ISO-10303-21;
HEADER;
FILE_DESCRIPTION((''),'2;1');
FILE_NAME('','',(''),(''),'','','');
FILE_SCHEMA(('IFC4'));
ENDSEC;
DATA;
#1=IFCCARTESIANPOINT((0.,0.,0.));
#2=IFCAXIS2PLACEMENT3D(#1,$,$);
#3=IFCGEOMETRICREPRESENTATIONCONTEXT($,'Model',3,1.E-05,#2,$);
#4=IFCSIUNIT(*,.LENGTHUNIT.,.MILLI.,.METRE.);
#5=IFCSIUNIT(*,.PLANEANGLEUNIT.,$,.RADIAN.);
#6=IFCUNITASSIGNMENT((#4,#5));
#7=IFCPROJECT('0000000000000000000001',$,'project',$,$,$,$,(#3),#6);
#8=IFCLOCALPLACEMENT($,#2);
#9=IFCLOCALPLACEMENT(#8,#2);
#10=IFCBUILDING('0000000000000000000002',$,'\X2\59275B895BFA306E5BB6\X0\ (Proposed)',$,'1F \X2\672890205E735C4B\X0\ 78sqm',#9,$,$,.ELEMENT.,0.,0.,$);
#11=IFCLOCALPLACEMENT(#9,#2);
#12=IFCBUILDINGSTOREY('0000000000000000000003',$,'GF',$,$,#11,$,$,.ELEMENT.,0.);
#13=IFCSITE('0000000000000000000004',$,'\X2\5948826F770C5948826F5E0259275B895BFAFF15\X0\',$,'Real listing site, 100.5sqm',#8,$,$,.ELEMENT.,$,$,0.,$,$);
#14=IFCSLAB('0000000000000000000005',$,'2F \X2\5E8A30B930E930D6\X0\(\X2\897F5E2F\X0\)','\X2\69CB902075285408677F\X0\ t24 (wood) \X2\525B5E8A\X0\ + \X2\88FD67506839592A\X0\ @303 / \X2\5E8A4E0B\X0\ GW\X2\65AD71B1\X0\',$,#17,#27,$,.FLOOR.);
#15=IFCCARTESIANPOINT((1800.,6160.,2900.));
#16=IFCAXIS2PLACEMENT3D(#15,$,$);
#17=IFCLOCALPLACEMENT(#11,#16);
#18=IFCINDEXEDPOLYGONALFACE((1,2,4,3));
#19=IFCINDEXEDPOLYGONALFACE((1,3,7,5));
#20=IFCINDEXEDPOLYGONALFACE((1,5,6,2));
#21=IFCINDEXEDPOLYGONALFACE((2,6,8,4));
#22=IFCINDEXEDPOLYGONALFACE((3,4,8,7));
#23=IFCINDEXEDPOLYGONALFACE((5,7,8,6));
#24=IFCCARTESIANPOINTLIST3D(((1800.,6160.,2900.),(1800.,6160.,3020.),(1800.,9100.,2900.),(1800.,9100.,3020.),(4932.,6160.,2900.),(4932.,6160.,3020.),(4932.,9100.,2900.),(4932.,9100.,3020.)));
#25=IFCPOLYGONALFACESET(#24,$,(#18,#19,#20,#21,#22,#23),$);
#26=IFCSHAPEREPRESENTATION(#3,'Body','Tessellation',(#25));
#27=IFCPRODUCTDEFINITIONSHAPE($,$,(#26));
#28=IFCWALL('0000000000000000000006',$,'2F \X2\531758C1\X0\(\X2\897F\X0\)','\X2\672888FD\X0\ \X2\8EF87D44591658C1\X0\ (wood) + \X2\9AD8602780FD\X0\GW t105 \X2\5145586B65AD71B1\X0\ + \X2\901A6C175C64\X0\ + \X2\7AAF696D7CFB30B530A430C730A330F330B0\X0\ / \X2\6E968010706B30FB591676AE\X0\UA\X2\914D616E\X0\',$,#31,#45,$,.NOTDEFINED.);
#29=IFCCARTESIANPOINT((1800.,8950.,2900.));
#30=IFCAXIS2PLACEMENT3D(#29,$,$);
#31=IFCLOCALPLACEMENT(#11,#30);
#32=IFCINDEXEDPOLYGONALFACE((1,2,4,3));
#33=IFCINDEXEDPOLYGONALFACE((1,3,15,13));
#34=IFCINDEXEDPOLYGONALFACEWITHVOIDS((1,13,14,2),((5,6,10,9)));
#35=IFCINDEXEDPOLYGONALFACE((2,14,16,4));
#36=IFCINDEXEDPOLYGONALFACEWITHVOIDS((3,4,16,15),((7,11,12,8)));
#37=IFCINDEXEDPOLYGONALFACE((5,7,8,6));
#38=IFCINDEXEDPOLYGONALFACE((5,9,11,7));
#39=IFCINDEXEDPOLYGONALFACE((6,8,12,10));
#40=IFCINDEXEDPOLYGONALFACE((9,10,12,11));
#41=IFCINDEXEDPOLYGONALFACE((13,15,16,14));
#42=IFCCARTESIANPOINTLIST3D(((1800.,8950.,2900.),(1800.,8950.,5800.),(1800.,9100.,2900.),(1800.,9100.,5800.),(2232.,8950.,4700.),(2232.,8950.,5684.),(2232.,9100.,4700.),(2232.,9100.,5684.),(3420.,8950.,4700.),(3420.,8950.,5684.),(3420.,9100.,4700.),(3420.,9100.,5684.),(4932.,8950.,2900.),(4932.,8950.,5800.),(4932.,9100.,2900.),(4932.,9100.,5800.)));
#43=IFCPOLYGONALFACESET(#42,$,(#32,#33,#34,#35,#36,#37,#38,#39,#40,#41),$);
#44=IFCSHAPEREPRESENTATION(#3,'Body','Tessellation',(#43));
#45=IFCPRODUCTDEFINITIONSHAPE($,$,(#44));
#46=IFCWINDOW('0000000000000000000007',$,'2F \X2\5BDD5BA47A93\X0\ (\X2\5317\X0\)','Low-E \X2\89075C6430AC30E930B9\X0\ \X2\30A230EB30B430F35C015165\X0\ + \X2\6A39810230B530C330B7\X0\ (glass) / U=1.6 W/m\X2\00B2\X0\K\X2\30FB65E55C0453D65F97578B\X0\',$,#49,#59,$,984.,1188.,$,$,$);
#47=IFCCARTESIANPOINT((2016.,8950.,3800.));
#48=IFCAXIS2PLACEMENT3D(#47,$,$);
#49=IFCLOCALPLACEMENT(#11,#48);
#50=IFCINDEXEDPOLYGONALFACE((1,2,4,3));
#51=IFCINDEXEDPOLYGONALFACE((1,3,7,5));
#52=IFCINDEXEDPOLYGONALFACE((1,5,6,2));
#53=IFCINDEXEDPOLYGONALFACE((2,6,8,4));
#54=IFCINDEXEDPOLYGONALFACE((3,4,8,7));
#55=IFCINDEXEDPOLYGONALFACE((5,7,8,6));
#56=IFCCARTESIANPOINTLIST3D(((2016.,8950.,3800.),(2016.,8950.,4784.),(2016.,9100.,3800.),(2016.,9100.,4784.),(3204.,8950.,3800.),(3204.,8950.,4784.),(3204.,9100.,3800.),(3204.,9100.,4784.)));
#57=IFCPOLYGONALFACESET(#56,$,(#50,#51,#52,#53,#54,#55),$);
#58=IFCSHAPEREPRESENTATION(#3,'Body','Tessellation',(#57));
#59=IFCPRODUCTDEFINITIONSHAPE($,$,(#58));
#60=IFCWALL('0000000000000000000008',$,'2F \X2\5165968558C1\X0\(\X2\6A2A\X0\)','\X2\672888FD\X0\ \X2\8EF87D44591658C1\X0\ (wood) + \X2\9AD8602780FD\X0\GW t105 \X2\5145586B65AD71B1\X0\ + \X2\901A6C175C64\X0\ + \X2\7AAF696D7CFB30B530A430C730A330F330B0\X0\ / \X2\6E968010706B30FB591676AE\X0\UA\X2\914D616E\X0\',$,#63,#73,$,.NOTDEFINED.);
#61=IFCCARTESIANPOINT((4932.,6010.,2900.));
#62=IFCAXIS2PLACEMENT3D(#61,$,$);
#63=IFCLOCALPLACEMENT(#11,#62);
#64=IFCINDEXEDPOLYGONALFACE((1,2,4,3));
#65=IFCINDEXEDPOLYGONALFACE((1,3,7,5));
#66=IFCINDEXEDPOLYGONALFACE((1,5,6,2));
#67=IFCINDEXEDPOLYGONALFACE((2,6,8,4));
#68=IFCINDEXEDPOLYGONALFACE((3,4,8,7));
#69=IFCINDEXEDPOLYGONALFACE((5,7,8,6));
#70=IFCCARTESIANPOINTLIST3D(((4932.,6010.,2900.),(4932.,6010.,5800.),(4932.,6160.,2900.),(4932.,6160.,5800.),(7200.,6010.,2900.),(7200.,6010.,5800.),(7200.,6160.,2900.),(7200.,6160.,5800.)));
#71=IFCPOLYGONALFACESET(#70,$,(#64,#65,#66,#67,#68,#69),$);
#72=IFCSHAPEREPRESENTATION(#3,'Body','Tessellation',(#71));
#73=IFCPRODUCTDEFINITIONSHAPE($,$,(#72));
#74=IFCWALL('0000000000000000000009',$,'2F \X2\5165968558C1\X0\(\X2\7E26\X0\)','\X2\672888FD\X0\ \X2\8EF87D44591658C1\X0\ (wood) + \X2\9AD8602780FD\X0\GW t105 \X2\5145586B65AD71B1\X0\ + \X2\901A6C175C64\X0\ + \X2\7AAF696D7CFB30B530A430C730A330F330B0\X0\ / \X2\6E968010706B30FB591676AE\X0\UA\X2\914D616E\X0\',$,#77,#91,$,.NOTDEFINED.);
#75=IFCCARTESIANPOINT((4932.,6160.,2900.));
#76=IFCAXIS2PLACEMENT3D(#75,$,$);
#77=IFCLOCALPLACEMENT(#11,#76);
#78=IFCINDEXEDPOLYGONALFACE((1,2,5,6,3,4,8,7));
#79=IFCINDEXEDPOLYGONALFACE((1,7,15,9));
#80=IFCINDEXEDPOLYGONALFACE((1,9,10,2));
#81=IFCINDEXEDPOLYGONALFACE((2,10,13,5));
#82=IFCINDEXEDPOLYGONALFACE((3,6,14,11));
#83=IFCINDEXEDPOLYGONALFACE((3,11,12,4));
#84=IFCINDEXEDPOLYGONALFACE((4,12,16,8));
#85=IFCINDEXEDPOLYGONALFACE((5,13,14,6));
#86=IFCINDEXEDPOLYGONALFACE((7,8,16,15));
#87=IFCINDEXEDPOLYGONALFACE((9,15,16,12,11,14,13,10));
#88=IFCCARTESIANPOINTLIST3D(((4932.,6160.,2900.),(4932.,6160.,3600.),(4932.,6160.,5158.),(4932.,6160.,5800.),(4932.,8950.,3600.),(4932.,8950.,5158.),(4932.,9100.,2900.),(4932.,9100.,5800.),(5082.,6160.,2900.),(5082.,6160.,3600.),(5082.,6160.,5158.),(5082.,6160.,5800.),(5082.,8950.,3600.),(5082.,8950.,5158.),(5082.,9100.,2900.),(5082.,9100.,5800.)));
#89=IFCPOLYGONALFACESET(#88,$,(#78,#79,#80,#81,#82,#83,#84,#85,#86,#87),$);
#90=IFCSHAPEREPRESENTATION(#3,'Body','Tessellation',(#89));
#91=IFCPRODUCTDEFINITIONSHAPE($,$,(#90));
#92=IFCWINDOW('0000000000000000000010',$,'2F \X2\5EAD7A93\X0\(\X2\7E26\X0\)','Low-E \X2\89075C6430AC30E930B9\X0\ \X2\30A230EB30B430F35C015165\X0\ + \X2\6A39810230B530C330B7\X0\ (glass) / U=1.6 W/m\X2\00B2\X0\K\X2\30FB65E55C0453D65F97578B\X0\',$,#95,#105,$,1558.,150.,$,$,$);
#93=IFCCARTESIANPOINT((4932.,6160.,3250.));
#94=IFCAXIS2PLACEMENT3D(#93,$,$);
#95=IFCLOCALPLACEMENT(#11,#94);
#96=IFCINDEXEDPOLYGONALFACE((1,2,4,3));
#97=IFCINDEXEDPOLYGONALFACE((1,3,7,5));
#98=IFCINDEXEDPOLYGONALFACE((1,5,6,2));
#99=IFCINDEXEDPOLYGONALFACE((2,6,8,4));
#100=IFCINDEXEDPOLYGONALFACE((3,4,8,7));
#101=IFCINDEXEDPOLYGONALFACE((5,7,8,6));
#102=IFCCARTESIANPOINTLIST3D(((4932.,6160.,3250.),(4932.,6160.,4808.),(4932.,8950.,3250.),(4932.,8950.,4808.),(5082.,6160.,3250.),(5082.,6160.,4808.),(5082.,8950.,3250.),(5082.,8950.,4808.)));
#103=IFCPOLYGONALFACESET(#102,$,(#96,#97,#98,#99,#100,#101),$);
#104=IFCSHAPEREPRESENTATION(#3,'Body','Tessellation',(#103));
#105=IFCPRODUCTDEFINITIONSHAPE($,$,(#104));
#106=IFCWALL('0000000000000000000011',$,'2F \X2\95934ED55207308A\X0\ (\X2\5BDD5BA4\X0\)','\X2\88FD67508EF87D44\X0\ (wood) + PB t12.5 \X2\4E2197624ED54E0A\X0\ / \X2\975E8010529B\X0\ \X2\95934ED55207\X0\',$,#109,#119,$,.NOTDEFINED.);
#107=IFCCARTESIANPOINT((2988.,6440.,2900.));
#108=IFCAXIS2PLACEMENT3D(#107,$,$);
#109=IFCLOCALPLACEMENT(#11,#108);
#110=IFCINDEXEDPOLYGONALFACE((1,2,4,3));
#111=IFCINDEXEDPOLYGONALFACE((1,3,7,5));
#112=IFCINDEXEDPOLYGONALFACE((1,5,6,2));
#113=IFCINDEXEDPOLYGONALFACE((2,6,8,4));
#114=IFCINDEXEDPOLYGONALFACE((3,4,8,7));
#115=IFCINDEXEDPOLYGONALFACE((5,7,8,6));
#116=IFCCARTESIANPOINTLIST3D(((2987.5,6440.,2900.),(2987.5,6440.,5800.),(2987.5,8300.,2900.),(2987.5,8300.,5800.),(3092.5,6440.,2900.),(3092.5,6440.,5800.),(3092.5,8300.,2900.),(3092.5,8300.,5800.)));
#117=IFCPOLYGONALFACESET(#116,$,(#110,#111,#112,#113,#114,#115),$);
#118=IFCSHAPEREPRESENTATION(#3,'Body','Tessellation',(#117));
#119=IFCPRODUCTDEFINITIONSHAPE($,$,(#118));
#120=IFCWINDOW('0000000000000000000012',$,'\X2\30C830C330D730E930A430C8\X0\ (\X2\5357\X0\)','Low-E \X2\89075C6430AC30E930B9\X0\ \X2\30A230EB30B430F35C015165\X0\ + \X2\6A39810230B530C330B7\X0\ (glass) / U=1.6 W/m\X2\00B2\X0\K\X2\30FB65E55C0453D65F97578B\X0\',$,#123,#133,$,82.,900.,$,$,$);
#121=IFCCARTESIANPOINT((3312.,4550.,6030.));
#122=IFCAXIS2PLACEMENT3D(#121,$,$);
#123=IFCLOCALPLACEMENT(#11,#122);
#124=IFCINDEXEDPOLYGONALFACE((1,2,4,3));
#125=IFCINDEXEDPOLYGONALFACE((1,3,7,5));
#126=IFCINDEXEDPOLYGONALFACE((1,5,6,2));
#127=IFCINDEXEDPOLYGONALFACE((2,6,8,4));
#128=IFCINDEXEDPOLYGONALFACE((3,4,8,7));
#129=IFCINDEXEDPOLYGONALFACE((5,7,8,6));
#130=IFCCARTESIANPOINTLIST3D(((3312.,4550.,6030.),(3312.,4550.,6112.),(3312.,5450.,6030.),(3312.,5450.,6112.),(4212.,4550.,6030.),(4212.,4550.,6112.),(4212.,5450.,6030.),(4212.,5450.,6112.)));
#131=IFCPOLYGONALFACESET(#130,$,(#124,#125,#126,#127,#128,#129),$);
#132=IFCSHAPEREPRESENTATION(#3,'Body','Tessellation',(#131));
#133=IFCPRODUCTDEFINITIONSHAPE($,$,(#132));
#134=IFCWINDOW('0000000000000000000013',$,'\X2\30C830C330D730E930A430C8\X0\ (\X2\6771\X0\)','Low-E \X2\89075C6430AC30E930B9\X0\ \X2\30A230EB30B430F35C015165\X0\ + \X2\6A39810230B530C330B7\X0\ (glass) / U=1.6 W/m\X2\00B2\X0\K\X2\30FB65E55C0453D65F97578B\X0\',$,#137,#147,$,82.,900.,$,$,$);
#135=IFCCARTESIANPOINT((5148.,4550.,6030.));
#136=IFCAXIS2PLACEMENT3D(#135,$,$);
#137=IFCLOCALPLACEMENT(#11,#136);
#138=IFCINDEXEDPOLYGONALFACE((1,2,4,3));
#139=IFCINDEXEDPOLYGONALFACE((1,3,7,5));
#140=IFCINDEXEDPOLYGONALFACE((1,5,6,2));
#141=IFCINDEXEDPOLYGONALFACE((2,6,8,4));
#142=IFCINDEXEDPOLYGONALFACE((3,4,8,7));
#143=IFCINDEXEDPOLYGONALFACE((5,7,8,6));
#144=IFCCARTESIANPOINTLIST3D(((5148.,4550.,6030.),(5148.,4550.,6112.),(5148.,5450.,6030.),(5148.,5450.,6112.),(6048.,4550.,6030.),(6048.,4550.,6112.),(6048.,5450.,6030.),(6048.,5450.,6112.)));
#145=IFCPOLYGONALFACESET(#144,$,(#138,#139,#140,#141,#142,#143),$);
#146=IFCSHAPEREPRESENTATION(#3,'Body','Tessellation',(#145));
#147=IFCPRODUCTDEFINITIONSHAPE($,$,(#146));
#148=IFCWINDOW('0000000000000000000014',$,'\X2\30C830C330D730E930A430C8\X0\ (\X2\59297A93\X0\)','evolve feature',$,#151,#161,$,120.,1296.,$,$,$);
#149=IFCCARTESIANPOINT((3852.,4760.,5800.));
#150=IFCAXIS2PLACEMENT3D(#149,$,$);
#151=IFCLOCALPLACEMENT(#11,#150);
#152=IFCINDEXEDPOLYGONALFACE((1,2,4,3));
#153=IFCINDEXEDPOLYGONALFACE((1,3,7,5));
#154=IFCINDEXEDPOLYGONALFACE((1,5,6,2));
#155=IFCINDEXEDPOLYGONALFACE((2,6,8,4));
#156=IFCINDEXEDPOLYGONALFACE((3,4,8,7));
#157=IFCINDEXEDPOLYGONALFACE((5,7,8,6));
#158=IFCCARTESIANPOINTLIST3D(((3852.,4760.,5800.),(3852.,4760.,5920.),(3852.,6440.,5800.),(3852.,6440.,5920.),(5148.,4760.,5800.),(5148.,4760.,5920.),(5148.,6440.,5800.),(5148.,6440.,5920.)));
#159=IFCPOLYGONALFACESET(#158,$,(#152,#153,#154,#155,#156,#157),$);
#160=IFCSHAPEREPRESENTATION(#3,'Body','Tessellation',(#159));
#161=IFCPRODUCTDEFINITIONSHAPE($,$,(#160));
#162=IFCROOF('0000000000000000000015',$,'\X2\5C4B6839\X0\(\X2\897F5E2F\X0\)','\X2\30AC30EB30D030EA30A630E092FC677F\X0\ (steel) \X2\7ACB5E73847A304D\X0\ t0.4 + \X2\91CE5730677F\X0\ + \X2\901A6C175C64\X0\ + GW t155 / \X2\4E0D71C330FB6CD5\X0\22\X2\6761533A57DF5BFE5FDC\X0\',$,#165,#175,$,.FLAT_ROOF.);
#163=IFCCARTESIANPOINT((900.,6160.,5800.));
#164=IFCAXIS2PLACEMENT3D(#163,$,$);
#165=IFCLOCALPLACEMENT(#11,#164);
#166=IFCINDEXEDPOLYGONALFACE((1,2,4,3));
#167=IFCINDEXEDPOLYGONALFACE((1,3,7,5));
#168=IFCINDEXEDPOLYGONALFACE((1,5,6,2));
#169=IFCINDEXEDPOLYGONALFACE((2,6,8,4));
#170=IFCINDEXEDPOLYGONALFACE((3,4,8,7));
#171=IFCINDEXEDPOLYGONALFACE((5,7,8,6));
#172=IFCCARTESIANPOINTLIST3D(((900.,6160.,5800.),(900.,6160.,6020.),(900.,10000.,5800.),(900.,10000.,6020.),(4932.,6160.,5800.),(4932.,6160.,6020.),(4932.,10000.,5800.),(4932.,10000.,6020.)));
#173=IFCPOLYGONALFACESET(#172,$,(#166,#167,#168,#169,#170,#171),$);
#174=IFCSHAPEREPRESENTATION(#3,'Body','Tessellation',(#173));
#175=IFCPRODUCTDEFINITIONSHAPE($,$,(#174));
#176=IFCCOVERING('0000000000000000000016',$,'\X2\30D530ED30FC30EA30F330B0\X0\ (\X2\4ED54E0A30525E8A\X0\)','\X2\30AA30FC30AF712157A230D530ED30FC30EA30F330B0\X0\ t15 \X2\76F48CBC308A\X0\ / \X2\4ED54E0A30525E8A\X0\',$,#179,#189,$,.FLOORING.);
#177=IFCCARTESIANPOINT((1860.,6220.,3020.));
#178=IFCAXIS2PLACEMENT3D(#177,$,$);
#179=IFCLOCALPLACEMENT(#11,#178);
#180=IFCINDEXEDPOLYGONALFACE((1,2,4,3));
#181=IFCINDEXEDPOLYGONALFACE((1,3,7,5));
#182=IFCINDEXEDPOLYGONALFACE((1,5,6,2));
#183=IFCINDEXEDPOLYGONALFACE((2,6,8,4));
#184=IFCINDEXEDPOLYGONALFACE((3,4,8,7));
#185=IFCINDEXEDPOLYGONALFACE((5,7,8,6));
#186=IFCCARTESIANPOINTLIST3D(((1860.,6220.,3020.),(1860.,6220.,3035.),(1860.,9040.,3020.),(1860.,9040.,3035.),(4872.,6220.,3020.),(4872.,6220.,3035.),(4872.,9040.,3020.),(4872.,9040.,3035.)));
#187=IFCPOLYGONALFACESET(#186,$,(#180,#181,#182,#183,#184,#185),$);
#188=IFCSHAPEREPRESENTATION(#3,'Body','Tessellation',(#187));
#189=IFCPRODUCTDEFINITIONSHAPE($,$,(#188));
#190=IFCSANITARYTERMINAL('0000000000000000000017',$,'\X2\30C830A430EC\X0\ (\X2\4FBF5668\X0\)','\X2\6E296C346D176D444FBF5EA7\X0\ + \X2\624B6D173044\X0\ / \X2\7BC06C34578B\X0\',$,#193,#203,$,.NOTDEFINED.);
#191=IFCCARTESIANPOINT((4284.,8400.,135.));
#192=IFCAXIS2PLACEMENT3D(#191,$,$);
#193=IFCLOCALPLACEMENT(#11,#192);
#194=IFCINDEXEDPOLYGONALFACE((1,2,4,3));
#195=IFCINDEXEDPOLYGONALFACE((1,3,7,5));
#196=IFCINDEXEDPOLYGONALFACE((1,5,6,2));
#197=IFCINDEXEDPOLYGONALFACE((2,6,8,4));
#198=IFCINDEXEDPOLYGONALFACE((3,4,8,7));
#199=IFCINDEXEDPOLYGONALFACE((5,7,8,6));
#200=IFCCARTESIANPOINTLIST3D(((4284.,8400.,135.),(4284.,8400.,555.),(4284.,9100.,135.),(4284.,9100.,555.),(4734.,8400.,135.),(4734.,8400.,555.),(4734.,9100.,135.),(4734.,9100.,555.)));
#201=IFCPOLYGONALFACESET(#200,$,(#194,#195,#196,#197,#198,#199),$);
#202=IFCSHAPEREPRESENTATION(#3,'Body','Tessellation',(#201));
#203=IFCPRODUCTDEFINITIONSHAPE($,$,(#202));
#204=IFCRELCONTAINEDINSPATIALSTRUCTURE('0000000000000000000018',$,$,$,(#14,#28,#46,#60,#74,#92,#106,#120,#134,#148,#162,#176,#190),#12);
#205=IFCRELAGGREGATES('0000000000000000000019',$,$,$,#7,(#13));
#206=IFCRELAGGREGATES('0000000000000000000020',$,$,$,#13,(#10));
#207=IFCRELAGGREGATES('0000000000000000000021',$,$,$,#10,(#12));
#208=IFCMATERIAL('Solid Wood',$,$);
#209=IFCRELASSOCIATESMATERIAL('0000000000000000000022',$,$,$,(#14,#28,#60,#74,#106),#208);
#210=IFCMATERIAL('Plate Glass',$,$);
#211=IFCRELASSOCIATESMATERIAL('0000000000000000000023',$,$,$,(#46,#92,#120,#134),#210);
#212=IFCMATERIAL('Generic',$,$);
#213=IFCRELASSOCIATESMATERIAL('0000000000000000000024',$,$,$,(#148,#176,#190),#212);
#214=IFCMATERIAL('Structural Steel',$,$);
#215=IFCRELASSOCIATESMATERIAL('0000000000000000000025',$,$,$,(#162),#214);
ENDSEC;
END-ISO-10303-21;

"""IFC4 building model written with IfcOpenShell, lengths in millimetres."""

from ifc_helpers import new_model, si_unit, frame, frame_2d, origin, place, context, project, spatial, rectangle, extrude, material, element, fill, save


model = new_model("IFC4")

# Units and contexts
model_context = context("Model", 3, precision=1e-05, world=origin())
ifc_project = project(units=[si_unit("LENGTHUNIT", "METRE", prefix="MILLI"), si_unit("PLANEANGLEUNIT", "RADIAN")], contexts=[model_context])

# Site, building, storey
site_placement = place(None, origin())
site = spatial("IfcSite", under=ifc_project, at=site_placement, Name="奈良県奈良市大安寺５", ObjectType="Real listing site, 100.5sqm", CompositionType="ELEMENT", RefElevation=0.0)
building_placement = place(site_placement, origin())
building = spatial("IfcBuilding", under=site, at=building_placement, Name="大安寺の家 (Proposed)", ObjectType="1F 木造平屋 78sqm", CompositionType="ELEMENT", ElevationOfRefHeight=0.0, ElevationOfTerrain=0.0)
storey_placement = place(building_placement, origin())
storey = spatial("IfcBuildingStorey", under=building, at=storey_placement, Name="GF", CompositionType="ELEMENT", Elevation=0.0)

# Slab
ifc_material_1 = material(Name="Solid Wood")
slab_placement = place(storey_placement, frame((1800.0, 6160.0, 2900.0)))
element("IfcSlab", 1, at=slab_placement, inside=storey, material=ifc_material_1, Name="2F 床スラブ(西帯)", Description="構造用合板 t24 (wood) 剛床 + 製材根太 @303 / 床下 GW断熱", PredefinedType="FLOOR", context=model_context, shape_type="SweptSolid", body=[
    extrude(rectangle(XDim=3132.0, YDim=2940.0, at=frame_2d((1566.0, 1470.0))), frame((1800.0, 6160.0, 2900.0)), (0.0, 0.0, 1.0), 120.0),
])

# Wall, opening, window
wall_1_placement = place(storey_placement, frame((1800.0, 8950.0, 2900.0)))
wall_1 = element("IfcWall", 2, at=wall_1_placement, inside=storey, material=ifc_material_1, Name="2F 北壁(西)", Description="木製 軸組外壁 (wood) + 高性能GW t105 充填断熱 + 通気層 + 窯業系サイディング / 準耐火・外皮UA配慮", PredefinedType="NOTDEFINED", context=model_context, shape_type="SweptSolid", body=[
    extrude(rectangle(XDim=3132.0, YDim=150.0, at=frame_2d((1566.0, 75.0))), frame((1800.0, 8950.0, 2900.0)), (0.0, 0.0, 1.0), 2900.0),
])
opening_1_placement = place(storey_placement, frame((2016.0, 8950.0, 3800.0)))
opening_1 = element("IfcOpeningElement", 3, at=opening_1_placement, cuts=wall_1, PredefinedType="NOTDEFINED", context=model_context, shape_type="SweptSolid", body=[
    extrude(rectangle(XDim=1188.0, YDim=150.0, at=frame_2d((594.0, 75.0))), frame((2016.0, 8950.0, 3800.0)), (0.0, 0.0, 1.0), 984.0),
])
ifc_material_2 = material(Name="Plate Glass")
window_1_placement = place(storey_placement, frame((2016.0, 8950.0, 3800.0)))
window_1 = element("IfcWindow", 4, at=window_1_placement, inside=storey, material=ifc_material_2, Name="2F 寝室窓 (北)", Description="Low-E 複層ガラス アルゴン封入 + 樹脂サッシ (glass) / U=1.6 W/m²K・日射取得型", OverallHeight=984.0, OverallWidth=1188.0, context=model_context, shape_type="SweptSolid", body=[
    extrude(rectangle(XDim=1188.0, YDim=150.0, at=frame_2d((594.0, 75.0))), frame((2016.0, 8950.0, 3800.0)), (0.0, 0.0, 1.0), 984.0),
])
fill(opening_1, window_1)

# Wall
wall_2_placement = place(storey_placement, frame((4932.0, 6010.0, 2900.0)))
element("IfcWall", 5, at=wall_2_placement, inside=storey, material=ifc_material_1, Name="2F 入隅壁(横)", Description="木製 軸組外壁 (wood) + 高性能GW t105 充填断熱 + 通気層 + 窯業系サイディング / 準耐火・外皮UA配慮", PredefinedType="NOTDEFINED", context=model_context, shape_type="SweptSolid", body=[
    extrude(rectangle(XDim=2268.0, YDim=150.0, at=frame_2d((1134.0, 75.0))), frame((4932.0, 6010.0, 2900.0)), (0.0, 0.0, 1.0), 2900.0),
])

# Wall, opening, window
wall_3_placement = place(storey_placement, frame((4932.0, 6160.0, 2900.0)))
wall_3 = element("IfcWall", 6, at=wall_3_placement, inside=storey, material=ifc_material_1, Name="2F 入隅壁(縦)", Description="木製 軸組外壁 (wood) + 高性能GW t105 充填断熱 + 通気層 + 窯業系サイディング / 準耐火・外皮UA配慮", PredefinedType="NOTDEFINED", context=model_context, shape_type="SweptSolid", body=[
    extrude(rectangle(XDim=150.0, YDim=2940.0, at=frame_2d((75.0, 1470.0))), frame((4932.0, 6160.0, 2900.0)), (0.0, 0.0, 1.0), 2900.0),
])
opening_2_placement = place(storey_placement, frame((4932.0, 6160.0, 3250.0)))
opening_2 = element("IfcOpeningElement", 7, at=opening_2_placement, cuts=wall_3, PredefinedType="NOTDEFINED", context=model_context, shape_type="SweptSolid", body=[
    extrude(rectangle(XDim=150.0, YDim=2790.0, at=frame_2d((75.0, 1395.0))), frame((4932.0, 6160.0, 3250.0)), (0.0, 0.0, 1.0), 1558.0),
])
window_2_placement = place(storey_placement, frame((4932.0, 6160.0, 3250.0)))
window_2 = element("IfcWindow", 8, at=window_2_placement, inside=storey, material=ifc_material_2, Name="2F 庭窓(縦)", Description="Low-E 複層ガラス アルゴン封入 + 樹脂サッシ (glass) / U=1.6 W/m²K・日射取得型", OverallHeight=1558.0, OverallWidth=150.0, context=model_context, shape_type="SweptSolid", body=[
    extrude(rectangle(XDim=150.0, YDim=2790.0, at=frame_2d((75.0, 1395.0))), frame((4932.0, 6160.0, 3250.0)), (0.0, 0.0, 1.0), 1558.0),
])
fill(opening_2, window_2)

# Wall
wall_4_placement = place(storey_placement, frame((2988.0, 6440.0, 2900.0)))
element("IfcWall", 9, at=wall_4_placement, inside=storey, material=ifc_material_1, Name="2F 間仕切り (寝室)", Description="製材軸組 (wood) + PB t12.5 両面仕上 / 非耐力 間仕切", PredefinedType="NOTDEFINED", context=model_context, shape_type="SweptSolid", body=[
    extrude(rectangle(XDim=105.0, YDim=1860.0, at=frame_2d((52.0, 930.0))), frame((2988.0, 6440.0, 2900.0)), (0.0, 0.0, 1.0), 2900.0),
])

# Windows
window_3_placement = place(storey_placement, frame((3312.0, 4550.0, 6030.0)))
element("IfcWindow", 10, at=window_3_placement, inside=storey, material=ifc_material_2, Name="トップライト (南)", Description="Low-E 複層ガラス アルゴン封入 + 樹脂サッシ (glass) / U=1.6 W/m²K・日射取得型", OverallHeight=82.0, OverallWidth=900.0, context=model_context, shape_type="SweptSolid", body=[
    extrude(rectangle(XDim=900.0, YDim=900.0, at=frame_2d((450.0, 450.0))), frame((3312.0, 4550.0, 6030.0)), (0.0, 0.0, 1.0), 82.0),
])
window_4_placement = place(storey_placement, frame((5148.0, 4550.0, 6030.0)))
element("IfcWindow", 11, at=window_4_placement, inside=storey, material=ifc_material_2, Name="トップライト (東)", Description="Low-E 複層ガラス アルゴン封入 + 樹脂サッシ (glass) / U=1.6 W/m²K・日射取得型", OverallHeight=82.0, OverallWidth=900.0, context=model_context, shape_type="SweptSolid", body=[
    extrude(rectangle(XDim=900.0, YDim=900.0, at=frame_2d((450.0, 450.0))), frame((5148.0, 4550.0, 6030.0)), (0.0, 0.0, 1.0), 82.0),
])
ifc_material_3 = material(Name="Generic")
window_5_placement = place(storey_placement, frame((3852.0, 4760.0, 5800.0)))
element("IfcWindow", 12, at=window_5_placement, inside=storey, material=ifc_material_3, Name="トップライト (天窓)", Description="evolve feature", OverallHeight=120.0, OverallWidth=1296.0, context=model_context, shape_type="SweptSolid", body=[
    extrude(rectangle(XDim=1296.0, YDim=1680.0, at=frame_2d((648.0, 840.0))), frame((3852.0, 4760.0, 5800.0)), (0.0, 0.0, 1.0), 120.0),
])

# Roof
ifc_material_4 = material(Name="Structural Steel")
for number, where, name in (
    (13, (900.0, 6160.0, 5800.0), "屋根(西帯)"),
):
    element("IfcRoof", number, at=place(storey_placement, frame(where)), inside=storey, material=ifc_material_4, Name=name, Description="ガルバリウム鋼板 (steel) 立平葺き t0.4 + 野地板 + 通気層 + GW t155 / 不燃・法22条区域対応", PredefinedType="FLAT_ROOF", context=model_context, shape_type="SweptSolid", body=[
        extrude(rectangle(XDim=4032.0, YDim=3840.0, at=frame_2d((2016.0, 1920.0))), frame((900.0, 6160.0, 5800.0)), (0.0, 0.0, 1.0), 220.0),
    ])

# Covering
covering_placement = place(storey_placement, frame((1860.0, 6220.0, 3020.0)))
element("IfcCovering", 14, at=covering_placement, inside=storey, material=ifc_material_3, Name="フローリング (仕上げ床)", Description="オーク無垢フローリング t15 直貼り / 仕上げ床", PredefinedType="FLOORING", context=model_context, shape_type="SweptSolid", body=[
    extrude(rectangle(XDim=3012.0, YDim=2820.0, at=frame_2d((1506.0, 1410.0))), frame((1860.0, 6220.0, 3020.0)), (0.0, 0.0, 1.0), 15.0),
])

# Sanitary terminal
sanitary_terminal_placement = place(storey_placement, frame((4284.0, 8400.0, 135.0)))
element("IfcSanitaryTerminal", 15, at=sanitary_terminal_placement, inside=storey, material=ifc_material_3, Name="トイレ (便器)", Description="温水洗浄便座 + 手洗い / 節水型", PredefinedType="NOTDEFINED", context=model_context, shape_type="SweptSolid", body=[
    extrude(rectangle(XDim=450.0, YDim=700.0, at=frame_2d((225.0, 350.0))), frame((4284.0, 8400.0, 135.0)), (0.0, 0.0, 1.0), 420.0),
])

save(model, "model.ifc")
